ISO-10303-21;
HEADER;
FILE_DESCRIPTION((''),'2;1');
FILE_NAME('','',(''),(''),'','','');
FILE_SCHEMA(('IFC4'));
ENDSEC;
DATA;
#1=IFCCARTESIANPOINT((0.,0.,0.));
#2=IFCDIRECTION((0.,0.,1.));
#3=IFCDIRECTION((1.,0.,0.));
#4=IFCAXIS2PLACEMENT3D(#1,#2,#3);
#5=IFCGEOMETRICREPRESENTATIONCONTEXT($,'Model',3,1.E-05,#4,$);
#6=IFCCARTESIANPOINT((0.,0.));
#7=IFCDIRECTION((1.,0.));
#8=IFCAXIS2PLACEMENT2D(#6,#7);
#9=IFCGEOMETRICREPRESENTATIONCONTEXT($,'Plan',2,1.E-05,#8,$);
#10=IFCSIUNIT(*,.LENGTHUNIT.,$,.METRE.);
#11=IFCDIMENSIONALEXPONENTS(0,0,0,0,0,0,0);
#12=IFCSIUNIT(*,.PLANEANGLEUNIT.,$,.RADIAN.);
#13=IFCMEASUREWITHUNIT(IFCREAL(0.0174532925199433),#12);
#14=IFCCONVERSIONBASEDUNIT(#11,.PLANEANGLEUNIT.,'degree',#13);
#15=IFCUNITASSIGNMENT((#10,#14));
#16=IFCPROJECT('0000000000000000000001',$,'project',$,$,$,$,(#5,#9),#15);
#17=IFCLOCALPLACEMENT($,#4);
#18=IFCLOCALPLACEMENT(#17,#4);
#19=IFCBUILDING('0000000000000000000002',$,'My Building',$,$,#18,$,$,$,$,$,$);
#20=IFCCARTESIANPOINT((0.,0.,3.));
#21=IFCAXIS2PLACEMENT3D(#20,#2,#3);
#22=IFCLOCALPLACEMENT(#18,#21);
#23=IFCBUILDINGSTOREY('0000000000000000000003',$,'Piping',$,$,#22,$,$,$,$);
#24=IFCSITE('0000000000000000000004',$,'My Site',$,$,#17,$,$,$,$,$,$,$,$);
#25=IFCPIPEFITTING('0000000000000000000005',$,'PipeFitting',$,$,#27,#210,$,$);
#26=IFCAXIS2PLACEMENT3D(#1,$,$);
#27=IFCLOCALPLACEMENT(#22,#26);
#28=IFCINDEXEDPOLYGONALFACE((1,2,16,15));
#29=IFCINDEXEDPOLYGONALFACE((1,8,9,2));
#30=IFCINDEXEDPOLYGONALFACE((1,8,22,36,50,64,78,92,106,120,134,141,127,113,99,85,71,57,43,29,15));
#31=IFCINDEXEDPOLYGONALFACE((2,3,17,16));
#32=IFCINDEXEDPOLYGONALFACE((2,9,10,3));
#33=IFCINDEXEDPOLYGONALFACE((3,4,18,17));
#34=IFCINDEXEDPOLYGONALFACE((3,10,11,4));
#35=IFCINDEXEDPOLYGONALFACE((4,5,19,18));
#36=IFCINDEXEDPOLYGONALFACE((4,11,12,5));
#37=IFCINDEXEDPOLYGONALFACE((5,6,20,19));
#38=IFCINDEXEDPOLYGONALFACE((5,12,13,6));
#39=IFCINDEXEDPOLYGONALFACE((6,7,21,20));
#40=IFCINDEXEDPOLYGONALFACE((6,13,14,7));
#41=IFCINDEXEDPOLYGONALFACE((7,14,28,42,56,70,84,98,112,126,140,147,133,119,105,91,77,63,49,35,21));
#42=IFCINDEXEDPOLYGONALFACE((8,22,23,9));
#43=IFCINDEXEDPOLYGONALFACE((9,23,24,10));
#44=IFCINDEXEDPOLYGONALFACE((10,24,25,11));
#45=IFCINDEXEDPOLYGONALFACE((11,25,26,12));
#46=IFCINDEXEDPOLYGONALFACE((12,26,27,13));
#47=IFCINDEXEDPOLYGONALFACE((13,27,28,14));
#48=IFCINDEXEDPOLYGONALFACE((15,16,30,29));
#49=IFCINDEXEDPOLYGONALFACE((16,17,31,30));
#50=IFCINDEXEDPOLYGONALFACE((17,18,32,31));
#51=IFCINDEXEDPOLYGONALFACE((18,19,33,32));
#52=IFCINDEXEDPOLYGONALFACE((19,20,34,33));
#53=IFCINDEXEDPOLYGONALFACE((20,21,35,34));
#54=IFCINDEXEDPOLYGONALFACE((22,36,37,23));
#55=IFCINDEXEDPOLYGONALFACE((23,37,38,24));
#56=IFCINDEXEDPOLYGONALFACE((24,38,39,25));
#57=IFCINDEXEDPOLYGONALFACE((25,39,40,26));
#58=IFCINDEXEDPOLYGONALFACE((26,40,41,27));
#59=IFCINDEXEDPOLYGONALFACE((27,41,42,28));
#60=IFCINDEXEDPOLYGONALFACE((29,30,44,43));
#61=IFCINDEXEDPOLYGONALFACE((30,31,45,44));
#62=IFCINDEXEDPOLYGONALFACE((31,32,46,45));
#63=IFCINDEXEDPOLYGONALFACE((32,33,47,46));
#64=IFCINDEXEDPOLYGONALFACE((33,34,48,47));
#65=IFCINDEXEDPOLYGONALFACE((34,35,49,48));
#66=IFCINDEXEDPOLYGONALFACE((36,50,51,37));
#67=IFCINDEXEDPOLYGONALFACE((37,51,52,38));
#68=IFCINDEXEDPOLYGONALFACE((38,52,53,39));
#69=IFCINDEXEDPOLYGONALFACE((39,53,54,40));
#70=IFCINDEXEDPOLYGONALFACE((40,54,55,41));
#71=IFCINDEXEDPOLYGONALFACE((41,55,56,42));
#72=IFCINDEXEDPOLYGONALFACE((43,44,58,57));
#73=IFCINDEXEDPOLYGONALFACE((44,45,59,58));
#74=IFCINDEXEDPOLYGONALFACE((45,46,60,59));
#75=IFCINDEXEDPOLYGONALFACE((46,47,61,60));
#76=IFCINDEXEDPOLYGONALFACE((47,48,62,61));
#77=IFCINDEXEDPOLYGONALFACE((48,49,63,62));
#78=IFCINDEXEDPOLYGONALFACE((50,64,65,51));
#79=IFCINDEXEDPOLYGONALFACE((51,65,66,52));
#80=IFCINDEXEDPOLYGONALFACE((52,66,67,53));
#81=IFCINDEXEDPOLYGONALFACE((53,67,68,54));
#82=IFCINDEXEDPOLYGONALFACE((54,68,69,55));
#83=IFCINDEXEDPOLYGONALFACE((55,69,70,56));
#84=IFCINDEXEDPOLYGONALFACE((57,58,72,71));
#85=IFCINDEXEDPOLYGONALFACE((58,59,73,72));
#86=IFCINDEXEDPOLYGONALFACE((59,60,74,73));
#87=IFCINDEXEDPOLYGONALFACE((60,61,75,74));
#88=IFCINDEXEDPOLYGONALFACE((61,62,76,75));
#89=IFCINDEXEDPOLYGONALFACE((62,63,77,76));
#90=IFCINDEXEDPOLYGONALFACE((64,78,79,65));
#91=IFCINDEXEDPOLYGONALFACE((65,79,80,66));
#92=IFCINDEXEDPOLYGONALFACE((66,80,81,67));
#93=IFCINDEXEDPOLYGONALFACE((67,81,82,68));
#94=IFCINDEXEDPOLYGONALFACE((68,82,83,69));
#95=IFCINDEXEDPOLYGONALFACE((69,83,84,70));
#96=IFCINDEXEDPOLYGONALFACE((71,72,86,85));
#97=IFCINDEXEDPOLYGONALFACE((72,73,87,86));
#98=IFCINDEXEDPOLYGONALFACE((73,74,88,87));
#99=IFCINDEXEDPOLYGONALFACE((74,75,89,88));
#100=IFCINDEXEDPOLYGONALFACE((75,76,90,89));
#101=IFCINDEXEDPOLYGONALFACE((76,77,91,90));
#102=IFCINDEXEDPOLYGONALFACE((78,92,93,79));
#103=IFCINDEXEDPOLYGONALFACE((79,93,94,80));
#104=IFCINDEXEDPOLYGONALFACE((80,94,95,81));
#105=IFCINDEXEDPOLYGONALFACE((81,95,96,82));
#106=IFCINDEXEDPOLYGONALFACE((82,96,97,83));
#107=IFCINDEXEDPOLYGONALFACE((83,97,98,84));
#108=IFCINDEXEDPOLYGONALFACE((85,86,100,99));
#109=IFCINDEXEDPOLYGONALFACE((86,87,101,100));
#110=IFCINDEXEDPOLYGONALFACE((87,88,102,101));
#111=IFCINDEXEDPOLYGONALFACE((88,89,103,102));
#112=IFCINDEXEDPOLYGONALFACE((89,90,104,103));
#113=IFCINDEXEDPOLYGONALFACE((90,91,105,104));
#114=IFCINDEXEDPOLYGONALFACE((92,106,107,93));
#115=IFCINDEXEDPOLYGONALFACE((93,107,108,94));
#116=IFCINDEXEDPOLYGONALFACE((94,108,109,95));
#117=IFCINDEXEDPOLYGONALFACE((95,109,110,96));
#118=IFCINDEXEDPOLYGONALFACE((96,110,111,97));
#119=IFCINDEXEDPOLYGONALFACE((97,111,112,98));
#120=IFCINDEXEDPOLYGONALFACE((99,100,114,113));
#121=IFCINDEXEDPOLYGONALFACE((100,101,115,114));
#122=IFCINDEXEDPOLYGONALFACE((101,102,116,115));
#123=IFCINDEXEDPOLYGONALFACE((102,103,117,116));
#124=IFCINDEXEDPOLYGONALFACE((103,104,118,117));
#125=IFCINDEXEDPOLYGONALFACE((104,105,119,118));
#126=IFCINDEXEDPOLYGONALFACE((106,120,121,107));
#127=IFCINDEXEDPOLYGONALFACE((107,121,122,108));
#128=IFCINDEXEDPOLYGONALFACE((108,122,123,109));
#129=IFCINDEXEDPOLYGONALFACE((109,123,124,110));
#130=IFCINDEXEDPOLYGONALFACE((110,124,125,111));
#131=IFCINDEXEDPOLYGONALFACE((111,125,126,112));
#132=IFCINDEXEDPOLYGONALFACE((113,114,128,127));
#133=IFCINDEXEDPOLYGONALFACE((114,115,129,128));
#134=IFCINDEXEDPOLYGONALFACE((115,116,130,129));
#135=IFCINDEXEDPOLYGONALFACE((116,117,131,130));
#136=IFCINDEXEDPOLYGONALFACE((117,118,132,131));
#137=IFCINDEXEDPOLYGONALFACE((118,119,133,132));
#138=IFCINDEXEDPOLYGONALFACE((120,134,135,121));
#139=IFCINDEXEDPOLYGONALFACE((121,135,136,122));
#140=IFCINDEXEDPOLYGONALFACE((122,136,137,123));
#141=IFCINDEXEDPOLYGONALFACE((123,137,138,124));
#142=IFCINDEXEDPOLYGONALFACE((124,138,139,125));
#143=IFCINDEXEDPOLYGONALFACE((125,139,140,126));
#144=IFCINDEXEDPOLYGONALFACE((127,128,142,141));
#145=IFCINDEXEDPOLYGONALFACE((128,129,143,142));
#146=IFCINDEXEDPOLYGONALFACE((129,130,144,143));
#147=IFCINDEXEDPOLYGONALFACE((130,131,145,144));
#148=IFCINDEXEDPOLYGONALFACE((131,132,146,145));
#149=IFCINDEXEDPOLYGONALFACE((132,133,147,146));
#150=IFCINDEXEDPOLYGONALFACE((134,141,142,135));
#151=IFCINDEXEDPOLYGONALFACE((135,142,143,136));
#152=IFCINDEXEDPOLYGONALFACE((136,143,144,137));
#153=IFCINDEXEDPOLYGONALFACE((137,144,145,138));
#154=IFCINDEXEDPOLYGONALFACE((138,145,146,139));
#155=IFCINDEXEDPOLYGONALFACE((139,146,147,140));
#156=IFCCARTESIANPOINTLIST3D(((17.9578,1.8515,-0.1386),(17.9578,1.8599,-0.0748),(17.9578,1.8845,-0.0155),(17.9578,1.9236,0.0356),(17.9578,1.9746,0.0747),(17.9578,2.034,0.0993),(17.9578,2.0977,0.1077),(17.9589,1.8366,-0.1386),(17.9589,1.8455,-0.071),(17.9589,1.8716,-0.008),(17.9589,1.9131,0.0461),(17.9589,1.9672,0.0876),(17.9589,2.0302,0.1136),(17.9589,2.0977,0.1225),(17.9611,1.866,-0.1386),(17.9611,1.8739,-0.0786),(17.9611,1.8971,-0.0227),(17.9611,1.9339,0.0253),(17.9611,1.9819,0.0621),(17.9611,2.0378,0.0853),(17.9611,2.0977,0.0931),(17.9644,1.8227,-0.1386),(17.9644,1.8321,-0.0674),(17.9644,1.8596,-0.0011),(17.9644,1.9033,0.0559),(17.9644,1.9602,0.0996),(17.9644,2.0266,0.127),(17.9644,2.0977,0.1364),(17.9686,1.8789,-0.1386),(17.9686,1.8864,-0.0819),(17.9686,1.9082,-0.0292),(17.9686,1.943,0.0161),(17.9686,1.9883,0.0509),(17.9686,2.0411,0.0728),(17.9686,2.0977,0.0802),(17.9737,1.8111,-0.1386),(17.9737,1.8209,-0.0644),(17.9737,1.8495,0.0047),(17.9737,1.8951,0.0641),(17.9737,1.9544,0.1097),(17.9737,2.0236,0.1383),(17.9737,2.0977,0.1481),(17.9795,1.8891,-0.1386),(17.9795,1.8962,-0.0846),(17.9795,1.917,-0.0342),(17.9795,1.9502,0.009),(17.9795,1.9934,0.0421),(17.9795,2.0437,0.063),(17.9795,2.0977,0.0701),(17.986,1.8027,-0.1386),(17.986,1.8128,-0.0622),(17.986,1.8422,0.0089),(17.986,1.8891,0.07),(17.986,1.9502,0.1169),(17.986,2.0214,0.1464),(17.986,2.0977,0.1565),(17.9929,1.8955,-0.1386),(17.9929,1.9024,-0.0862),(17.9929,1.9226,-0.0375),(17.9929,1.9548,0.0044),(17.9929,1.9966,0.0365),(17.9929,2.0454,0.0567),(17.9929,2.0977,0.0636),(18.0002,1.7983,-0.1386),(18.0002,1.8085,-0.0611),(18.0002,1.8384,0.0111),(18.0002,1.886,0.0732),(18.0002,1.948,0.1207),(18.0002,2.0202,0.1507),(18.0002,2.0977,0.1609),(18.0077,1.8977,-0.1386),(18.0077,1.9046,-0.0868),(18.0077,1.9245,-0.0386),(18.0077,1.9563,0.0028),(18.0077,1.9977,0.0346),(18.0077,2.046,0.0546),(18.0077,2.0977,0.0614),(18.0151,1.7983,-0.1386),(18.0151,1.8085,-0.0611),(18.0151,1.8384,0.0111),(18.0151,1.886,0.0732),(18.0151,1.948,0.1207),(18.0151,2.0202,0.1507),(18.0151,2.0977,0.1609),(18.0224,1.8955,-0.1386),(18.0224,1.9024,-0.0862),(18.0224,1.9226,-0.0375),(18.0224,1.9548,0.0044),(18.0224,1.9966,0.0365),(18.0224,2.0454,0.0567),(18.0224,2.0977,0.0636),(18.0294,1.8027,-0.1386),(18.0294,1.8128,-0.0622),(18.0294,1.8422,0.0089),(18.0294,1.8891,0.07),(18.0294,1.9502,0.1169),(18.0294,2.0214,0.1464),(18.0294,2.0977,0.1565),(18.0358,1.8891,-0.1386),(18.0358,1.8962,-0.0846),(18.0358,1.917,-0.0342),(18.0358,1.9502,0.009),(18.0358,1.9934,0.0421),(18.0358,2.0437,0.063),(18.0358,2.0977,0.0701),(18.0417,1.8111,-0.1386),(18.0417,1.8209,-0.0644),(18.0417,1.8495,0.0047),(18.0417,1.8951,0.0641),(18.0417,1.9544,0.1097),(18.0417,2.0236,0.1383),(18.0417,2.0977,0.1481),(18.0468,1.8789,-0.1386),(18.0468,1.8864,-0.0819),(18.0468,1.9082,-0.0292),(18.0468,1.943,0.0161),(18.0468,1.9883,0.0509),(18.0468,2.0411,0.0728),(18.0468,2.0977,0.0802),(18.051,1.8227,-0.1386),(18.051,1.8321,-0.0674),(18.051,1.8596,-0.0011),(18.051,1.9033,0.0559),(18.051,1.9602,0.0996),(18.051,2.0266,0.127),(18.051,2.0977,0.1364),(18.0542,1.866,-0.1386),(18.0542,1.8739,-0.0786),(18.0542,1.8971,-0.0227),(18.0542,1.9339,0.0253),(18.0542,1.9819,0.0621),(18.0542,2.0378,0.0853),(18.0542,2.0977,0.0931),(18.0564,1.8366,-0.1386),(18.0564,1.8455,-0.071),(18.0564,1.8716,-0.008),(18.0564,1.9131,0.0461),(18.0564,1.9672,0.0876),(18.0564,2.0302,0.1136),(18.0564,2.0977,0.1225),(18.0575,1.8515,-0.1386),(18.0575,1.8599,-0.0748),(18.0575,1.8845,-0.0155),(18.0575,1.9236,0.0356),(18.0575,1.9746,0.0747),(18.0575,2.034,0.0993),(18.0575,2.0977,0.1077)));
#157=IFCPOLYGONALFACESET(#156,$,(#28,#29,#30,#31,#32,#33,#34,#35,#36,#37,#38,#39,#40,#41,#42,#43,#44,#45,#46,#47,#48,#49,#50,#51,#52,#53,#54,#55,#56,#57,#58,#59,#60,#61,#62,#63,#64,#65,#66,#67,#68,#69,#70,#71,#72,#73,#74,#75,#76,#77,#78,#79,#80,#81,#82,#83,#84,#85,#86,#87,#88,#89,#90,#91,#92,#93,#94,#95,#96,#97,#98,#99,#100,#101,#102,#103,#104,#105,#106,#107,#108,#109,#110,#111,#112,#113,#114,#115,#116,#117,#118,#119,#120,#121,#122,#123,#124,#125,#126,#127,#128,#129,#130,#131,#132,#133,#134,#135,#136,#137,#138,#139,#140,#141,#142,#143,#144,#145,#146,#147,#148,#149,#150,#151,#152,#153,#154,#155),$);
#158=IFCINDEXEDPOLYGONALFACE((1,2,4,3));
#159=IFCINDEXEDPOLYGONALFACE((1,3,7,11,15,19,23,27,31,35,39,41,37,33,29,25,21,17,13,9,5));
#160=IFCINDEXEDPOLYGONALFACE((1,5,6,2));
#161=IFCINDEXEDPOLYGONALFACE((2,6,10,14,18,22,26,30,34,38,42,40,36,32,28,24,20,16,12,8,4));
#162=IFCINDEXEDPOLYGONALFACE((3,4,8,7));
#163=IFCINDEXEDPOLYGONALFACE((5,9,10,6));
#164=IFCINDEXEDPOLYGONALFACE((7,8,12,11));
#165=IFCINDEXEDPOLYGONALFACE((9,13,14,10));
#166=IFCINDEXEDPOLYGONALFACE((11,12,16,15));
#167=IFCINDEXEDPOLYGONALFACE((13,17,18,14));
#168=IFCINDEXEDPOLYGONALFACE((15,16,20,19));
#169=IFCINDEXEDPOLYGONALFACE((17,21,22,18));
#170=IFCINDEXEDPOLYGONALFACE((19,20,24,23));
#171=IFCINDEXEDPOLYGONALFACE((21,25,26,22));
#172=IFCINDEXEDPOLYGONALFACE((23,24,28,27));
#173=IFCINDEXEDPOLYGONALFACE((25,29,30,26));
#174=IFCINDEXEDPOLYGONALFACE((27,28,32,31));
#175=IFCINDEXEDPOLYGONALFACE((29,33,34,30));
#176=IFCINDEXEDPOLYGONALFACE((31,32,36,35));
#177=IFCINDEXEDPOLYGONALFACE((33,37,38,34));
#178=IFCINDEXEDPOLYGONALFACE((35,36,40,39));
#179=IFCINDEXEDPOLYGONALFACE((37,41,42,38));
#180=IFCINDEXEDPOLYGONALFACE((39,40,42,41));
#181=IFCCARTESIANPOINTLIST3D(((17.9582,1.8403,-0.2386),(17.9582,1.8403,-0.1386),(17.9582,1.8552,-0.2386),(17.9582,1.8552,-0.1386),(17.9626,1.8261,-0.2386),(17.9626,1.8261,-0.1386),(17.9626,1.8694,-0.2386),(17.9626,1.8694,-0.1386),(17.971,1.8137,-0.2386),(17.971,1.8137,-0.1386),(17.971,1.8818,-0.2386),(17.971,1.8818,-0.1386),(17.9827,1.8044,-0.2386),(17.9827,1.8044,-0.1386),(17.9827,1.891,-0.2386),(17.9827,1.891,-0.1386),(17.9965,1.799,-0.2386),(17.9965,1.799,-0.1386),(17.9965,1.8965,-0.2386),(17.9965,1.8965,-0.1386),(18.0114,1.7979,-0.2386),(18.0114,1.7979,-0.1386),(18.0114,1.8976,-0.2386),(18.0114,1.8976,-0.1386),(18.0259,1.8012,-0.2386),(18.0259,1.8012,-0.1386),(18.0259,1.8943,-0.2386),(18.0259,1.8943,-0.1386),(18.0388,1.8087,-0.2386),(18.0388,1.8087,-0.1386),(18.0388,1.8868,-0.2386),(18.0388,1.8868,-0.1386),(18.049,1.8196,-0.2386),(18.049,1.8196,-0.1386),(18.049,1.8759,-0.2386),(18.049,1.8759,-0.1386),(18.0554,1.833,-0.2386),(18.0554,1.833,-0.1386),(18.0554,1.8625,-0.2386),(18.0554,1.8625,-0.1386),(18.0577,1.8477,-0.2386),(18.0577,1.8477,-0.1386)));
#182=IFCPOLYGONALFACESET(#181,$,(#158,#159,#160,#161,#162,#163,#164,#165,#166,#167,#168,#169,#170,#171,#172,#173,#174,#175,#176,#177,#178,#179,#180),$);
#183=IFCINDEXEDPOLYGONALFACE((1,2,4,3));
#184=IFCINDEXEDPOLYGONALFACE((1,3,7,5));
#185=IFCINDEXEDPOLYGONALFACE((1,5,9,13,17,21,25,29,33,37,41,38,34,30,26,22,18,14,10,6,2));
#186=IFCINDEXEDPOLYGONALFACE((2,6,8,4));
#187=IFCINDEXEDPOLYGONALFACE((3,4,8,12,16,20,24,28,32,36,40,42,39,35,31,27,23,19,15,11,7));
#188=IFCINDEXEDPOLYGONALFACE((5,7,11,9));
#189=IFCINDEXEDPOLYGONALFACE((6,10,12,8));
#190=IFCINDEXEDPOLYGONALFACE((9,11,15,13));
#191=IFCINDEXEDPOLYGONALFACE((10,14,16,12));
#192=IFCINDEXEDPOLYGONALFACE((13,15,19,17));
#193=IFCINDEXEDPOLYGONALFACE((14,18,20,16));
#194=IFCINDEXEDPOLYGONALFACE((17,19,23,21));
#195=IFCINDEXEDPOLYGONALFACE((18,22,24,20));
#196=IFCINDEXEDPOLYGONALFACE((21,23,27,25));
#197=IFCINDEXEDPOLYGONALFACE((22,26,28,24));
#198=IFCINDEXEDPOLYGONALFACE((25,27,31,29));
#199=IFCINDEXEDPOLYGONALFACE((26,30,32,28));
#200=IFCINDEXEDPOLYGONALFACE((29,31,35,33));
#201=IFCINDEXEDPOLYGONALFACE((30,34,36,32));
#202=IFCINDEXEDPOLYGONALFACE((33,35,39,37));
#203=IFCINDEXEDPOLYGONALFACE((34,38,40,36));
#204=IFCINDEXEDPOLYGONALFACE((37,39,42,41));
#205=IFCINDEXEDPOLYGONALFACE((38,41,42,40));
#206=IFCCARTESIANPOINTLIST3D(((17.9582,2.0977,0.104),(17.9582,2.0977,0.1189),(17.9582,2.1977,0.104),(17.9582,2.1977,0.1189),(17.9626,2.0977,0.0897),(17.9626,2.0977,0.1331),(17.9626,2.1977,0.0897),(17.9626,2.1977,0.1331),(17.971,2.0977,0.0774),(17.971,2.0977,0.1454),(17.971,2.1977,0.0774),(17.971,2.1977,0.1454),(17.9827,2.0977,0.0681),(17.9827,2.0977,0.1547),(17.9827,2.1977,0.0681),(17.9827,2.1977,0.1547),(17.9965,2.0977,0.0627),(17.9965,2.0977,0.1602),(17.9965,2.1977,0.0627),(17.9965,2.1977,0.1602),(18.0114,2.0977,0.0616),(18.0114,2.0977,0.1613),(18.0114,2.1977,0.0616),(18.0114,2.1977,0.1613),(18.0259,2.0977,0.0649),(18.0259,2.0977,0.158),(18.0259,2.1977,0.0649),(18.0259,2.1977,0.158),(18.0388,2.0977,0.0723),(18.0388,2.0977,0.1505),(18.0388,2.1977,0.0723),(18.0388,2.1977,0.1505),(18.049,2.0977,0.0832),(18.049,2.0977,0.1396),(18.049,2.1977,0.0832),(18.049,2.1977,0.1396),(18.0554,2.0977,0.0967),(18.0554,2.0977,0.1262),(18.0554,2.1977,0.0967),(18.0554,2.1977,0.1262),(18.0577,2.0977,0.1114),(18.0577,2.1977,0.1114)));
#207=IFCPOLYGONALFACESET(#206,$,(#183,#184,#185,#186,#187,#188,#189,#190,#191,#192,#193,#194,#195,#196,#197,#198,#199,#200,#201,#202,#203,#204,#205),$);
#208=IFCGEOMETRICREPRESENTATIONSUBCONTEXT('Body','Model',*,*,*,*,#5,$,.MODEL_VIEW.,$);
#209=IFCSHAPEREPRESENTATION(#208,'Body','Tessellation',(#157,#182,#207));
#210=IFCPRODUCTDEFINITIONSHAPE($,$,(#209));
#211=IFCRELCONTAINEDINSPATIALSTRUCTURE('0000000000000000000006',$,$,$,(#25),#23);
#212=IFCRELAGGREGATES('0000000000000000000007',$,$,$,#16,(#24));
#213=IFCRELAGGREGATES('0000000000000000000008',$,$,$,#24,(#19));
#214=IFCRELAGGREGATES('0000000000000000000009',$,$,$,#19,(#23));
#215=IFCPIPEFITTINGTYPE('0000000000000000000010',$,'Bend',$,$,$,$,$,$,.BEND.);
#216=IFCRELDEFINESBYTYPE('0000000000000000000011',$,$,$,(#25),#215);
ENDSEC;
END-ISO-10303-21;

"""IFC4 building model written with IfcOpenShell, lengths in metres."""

from ifc_helpers import new_model, entity, si_unit, converted_unit, frame, origin_with_axes, origin_2d_with_axis, place, context, subcontext, project, spatial, circle, extrude, source, transform, mapped, type_object, type_shapes, element, save


model = new_model("IFC4")

# Units and contexts
model_context = context("Model", 3, precision=1e-05, world=origin_with_axes())
plan_context = context("Plan", 2, precision=1e-05, world=origin_2d_with_axis())
body_context = subcontext(model_context, "Body", "Model", "MODEL_VIEW")
ifc_project = project(units=[si_unit("LENGTHUNIT", "METRE"), converted_unit("PLANEANGLEUNIT", "degree", entity("IfcReal", 0.0174532925199433), si_unit("PLANEANGLEUNIT", "RADIAN"), dimensions=[0, 0, 0, 0, 0, 0, 0])], contexts=[model_context, plan_context])

# Site, building, storey
site_placement = place(None, origin_with_axes())
site = spatial("IfcSite", under=ifc_project, at=site_placement, Name="My Site")
building_placement = place(site_placement, origin_with_axes())
building = spatial("IfcBuilding", under=site, at=building_placement, Name="My Building")
storey_placement = place(building_placement, frame((0.0, 0.0, 3.0), z_axis=(0.0, 0.0, 1.0), x_axis=(1.0, 0.0, 0.0)))
storey = spatial("IfcBuildingStorey", under=building, at=storey_placement, Name="Piping")

# Pipe fitting
pipe_fitting_type_1 = type_object("IfcPipeFittingType", Name="Bend", PredefinedType="BEND")
shared_shape = source(origin_with_axes(), body_context, "Body", "SolidModel", [
    entity("IfcSweptDiskSolid", entity("IfcIndexedPolyCurve", entity("IfcCartesianPointList3D", [[0.0, 0.0, -0.1], [0.0, -0.0732, -0.2768], [0.0, -0.25, -0.35]]), [entity("IfcArcIndex", [1, 2, 3])]), 0.05),
    extrude(circle(Radius=0.05), origin_with_axes(), (0.0, 0.0, -1.0), 0.1),
    extrude(circle(Radius=0.05), frame((0.0, -0.25, -0.35), z_axis=(0.0, -1.0, 0.0), x_axis=(1.0, 0.0, 0.0)), (0.0, 0.0, 1.0), 0.1),
])
type_shapes(pipe_fitting_type_1, [shared_shape])
for number, where, z_axis, x_axis, name in (
    (1, (18.0077, 1.8477, -0.2386), (0.0, 0.0, -1.0), (1.0, 0.0, 0.0), "PipeFitting"),
):
    element("IfcPipeFitting", number, at=place(storey_placement, frame(where, z_axis=z_axis, x_axis=x_axis)), inside=storey, type_object=pipe_fitting_type_1, Name=name, context=body_context, shape_type="MappedRepresentation", body=[
        mapped(shared_shape, transform((0.0, 0.0, 0.0), x_axis=(1.0, 0.0, 0.0), y_axis=(0.0, 1.0, 0.0), z_axis=(0.0, 0.0, 1.0), scale=1.0)),
    ])

save(model, "model.ifc")
